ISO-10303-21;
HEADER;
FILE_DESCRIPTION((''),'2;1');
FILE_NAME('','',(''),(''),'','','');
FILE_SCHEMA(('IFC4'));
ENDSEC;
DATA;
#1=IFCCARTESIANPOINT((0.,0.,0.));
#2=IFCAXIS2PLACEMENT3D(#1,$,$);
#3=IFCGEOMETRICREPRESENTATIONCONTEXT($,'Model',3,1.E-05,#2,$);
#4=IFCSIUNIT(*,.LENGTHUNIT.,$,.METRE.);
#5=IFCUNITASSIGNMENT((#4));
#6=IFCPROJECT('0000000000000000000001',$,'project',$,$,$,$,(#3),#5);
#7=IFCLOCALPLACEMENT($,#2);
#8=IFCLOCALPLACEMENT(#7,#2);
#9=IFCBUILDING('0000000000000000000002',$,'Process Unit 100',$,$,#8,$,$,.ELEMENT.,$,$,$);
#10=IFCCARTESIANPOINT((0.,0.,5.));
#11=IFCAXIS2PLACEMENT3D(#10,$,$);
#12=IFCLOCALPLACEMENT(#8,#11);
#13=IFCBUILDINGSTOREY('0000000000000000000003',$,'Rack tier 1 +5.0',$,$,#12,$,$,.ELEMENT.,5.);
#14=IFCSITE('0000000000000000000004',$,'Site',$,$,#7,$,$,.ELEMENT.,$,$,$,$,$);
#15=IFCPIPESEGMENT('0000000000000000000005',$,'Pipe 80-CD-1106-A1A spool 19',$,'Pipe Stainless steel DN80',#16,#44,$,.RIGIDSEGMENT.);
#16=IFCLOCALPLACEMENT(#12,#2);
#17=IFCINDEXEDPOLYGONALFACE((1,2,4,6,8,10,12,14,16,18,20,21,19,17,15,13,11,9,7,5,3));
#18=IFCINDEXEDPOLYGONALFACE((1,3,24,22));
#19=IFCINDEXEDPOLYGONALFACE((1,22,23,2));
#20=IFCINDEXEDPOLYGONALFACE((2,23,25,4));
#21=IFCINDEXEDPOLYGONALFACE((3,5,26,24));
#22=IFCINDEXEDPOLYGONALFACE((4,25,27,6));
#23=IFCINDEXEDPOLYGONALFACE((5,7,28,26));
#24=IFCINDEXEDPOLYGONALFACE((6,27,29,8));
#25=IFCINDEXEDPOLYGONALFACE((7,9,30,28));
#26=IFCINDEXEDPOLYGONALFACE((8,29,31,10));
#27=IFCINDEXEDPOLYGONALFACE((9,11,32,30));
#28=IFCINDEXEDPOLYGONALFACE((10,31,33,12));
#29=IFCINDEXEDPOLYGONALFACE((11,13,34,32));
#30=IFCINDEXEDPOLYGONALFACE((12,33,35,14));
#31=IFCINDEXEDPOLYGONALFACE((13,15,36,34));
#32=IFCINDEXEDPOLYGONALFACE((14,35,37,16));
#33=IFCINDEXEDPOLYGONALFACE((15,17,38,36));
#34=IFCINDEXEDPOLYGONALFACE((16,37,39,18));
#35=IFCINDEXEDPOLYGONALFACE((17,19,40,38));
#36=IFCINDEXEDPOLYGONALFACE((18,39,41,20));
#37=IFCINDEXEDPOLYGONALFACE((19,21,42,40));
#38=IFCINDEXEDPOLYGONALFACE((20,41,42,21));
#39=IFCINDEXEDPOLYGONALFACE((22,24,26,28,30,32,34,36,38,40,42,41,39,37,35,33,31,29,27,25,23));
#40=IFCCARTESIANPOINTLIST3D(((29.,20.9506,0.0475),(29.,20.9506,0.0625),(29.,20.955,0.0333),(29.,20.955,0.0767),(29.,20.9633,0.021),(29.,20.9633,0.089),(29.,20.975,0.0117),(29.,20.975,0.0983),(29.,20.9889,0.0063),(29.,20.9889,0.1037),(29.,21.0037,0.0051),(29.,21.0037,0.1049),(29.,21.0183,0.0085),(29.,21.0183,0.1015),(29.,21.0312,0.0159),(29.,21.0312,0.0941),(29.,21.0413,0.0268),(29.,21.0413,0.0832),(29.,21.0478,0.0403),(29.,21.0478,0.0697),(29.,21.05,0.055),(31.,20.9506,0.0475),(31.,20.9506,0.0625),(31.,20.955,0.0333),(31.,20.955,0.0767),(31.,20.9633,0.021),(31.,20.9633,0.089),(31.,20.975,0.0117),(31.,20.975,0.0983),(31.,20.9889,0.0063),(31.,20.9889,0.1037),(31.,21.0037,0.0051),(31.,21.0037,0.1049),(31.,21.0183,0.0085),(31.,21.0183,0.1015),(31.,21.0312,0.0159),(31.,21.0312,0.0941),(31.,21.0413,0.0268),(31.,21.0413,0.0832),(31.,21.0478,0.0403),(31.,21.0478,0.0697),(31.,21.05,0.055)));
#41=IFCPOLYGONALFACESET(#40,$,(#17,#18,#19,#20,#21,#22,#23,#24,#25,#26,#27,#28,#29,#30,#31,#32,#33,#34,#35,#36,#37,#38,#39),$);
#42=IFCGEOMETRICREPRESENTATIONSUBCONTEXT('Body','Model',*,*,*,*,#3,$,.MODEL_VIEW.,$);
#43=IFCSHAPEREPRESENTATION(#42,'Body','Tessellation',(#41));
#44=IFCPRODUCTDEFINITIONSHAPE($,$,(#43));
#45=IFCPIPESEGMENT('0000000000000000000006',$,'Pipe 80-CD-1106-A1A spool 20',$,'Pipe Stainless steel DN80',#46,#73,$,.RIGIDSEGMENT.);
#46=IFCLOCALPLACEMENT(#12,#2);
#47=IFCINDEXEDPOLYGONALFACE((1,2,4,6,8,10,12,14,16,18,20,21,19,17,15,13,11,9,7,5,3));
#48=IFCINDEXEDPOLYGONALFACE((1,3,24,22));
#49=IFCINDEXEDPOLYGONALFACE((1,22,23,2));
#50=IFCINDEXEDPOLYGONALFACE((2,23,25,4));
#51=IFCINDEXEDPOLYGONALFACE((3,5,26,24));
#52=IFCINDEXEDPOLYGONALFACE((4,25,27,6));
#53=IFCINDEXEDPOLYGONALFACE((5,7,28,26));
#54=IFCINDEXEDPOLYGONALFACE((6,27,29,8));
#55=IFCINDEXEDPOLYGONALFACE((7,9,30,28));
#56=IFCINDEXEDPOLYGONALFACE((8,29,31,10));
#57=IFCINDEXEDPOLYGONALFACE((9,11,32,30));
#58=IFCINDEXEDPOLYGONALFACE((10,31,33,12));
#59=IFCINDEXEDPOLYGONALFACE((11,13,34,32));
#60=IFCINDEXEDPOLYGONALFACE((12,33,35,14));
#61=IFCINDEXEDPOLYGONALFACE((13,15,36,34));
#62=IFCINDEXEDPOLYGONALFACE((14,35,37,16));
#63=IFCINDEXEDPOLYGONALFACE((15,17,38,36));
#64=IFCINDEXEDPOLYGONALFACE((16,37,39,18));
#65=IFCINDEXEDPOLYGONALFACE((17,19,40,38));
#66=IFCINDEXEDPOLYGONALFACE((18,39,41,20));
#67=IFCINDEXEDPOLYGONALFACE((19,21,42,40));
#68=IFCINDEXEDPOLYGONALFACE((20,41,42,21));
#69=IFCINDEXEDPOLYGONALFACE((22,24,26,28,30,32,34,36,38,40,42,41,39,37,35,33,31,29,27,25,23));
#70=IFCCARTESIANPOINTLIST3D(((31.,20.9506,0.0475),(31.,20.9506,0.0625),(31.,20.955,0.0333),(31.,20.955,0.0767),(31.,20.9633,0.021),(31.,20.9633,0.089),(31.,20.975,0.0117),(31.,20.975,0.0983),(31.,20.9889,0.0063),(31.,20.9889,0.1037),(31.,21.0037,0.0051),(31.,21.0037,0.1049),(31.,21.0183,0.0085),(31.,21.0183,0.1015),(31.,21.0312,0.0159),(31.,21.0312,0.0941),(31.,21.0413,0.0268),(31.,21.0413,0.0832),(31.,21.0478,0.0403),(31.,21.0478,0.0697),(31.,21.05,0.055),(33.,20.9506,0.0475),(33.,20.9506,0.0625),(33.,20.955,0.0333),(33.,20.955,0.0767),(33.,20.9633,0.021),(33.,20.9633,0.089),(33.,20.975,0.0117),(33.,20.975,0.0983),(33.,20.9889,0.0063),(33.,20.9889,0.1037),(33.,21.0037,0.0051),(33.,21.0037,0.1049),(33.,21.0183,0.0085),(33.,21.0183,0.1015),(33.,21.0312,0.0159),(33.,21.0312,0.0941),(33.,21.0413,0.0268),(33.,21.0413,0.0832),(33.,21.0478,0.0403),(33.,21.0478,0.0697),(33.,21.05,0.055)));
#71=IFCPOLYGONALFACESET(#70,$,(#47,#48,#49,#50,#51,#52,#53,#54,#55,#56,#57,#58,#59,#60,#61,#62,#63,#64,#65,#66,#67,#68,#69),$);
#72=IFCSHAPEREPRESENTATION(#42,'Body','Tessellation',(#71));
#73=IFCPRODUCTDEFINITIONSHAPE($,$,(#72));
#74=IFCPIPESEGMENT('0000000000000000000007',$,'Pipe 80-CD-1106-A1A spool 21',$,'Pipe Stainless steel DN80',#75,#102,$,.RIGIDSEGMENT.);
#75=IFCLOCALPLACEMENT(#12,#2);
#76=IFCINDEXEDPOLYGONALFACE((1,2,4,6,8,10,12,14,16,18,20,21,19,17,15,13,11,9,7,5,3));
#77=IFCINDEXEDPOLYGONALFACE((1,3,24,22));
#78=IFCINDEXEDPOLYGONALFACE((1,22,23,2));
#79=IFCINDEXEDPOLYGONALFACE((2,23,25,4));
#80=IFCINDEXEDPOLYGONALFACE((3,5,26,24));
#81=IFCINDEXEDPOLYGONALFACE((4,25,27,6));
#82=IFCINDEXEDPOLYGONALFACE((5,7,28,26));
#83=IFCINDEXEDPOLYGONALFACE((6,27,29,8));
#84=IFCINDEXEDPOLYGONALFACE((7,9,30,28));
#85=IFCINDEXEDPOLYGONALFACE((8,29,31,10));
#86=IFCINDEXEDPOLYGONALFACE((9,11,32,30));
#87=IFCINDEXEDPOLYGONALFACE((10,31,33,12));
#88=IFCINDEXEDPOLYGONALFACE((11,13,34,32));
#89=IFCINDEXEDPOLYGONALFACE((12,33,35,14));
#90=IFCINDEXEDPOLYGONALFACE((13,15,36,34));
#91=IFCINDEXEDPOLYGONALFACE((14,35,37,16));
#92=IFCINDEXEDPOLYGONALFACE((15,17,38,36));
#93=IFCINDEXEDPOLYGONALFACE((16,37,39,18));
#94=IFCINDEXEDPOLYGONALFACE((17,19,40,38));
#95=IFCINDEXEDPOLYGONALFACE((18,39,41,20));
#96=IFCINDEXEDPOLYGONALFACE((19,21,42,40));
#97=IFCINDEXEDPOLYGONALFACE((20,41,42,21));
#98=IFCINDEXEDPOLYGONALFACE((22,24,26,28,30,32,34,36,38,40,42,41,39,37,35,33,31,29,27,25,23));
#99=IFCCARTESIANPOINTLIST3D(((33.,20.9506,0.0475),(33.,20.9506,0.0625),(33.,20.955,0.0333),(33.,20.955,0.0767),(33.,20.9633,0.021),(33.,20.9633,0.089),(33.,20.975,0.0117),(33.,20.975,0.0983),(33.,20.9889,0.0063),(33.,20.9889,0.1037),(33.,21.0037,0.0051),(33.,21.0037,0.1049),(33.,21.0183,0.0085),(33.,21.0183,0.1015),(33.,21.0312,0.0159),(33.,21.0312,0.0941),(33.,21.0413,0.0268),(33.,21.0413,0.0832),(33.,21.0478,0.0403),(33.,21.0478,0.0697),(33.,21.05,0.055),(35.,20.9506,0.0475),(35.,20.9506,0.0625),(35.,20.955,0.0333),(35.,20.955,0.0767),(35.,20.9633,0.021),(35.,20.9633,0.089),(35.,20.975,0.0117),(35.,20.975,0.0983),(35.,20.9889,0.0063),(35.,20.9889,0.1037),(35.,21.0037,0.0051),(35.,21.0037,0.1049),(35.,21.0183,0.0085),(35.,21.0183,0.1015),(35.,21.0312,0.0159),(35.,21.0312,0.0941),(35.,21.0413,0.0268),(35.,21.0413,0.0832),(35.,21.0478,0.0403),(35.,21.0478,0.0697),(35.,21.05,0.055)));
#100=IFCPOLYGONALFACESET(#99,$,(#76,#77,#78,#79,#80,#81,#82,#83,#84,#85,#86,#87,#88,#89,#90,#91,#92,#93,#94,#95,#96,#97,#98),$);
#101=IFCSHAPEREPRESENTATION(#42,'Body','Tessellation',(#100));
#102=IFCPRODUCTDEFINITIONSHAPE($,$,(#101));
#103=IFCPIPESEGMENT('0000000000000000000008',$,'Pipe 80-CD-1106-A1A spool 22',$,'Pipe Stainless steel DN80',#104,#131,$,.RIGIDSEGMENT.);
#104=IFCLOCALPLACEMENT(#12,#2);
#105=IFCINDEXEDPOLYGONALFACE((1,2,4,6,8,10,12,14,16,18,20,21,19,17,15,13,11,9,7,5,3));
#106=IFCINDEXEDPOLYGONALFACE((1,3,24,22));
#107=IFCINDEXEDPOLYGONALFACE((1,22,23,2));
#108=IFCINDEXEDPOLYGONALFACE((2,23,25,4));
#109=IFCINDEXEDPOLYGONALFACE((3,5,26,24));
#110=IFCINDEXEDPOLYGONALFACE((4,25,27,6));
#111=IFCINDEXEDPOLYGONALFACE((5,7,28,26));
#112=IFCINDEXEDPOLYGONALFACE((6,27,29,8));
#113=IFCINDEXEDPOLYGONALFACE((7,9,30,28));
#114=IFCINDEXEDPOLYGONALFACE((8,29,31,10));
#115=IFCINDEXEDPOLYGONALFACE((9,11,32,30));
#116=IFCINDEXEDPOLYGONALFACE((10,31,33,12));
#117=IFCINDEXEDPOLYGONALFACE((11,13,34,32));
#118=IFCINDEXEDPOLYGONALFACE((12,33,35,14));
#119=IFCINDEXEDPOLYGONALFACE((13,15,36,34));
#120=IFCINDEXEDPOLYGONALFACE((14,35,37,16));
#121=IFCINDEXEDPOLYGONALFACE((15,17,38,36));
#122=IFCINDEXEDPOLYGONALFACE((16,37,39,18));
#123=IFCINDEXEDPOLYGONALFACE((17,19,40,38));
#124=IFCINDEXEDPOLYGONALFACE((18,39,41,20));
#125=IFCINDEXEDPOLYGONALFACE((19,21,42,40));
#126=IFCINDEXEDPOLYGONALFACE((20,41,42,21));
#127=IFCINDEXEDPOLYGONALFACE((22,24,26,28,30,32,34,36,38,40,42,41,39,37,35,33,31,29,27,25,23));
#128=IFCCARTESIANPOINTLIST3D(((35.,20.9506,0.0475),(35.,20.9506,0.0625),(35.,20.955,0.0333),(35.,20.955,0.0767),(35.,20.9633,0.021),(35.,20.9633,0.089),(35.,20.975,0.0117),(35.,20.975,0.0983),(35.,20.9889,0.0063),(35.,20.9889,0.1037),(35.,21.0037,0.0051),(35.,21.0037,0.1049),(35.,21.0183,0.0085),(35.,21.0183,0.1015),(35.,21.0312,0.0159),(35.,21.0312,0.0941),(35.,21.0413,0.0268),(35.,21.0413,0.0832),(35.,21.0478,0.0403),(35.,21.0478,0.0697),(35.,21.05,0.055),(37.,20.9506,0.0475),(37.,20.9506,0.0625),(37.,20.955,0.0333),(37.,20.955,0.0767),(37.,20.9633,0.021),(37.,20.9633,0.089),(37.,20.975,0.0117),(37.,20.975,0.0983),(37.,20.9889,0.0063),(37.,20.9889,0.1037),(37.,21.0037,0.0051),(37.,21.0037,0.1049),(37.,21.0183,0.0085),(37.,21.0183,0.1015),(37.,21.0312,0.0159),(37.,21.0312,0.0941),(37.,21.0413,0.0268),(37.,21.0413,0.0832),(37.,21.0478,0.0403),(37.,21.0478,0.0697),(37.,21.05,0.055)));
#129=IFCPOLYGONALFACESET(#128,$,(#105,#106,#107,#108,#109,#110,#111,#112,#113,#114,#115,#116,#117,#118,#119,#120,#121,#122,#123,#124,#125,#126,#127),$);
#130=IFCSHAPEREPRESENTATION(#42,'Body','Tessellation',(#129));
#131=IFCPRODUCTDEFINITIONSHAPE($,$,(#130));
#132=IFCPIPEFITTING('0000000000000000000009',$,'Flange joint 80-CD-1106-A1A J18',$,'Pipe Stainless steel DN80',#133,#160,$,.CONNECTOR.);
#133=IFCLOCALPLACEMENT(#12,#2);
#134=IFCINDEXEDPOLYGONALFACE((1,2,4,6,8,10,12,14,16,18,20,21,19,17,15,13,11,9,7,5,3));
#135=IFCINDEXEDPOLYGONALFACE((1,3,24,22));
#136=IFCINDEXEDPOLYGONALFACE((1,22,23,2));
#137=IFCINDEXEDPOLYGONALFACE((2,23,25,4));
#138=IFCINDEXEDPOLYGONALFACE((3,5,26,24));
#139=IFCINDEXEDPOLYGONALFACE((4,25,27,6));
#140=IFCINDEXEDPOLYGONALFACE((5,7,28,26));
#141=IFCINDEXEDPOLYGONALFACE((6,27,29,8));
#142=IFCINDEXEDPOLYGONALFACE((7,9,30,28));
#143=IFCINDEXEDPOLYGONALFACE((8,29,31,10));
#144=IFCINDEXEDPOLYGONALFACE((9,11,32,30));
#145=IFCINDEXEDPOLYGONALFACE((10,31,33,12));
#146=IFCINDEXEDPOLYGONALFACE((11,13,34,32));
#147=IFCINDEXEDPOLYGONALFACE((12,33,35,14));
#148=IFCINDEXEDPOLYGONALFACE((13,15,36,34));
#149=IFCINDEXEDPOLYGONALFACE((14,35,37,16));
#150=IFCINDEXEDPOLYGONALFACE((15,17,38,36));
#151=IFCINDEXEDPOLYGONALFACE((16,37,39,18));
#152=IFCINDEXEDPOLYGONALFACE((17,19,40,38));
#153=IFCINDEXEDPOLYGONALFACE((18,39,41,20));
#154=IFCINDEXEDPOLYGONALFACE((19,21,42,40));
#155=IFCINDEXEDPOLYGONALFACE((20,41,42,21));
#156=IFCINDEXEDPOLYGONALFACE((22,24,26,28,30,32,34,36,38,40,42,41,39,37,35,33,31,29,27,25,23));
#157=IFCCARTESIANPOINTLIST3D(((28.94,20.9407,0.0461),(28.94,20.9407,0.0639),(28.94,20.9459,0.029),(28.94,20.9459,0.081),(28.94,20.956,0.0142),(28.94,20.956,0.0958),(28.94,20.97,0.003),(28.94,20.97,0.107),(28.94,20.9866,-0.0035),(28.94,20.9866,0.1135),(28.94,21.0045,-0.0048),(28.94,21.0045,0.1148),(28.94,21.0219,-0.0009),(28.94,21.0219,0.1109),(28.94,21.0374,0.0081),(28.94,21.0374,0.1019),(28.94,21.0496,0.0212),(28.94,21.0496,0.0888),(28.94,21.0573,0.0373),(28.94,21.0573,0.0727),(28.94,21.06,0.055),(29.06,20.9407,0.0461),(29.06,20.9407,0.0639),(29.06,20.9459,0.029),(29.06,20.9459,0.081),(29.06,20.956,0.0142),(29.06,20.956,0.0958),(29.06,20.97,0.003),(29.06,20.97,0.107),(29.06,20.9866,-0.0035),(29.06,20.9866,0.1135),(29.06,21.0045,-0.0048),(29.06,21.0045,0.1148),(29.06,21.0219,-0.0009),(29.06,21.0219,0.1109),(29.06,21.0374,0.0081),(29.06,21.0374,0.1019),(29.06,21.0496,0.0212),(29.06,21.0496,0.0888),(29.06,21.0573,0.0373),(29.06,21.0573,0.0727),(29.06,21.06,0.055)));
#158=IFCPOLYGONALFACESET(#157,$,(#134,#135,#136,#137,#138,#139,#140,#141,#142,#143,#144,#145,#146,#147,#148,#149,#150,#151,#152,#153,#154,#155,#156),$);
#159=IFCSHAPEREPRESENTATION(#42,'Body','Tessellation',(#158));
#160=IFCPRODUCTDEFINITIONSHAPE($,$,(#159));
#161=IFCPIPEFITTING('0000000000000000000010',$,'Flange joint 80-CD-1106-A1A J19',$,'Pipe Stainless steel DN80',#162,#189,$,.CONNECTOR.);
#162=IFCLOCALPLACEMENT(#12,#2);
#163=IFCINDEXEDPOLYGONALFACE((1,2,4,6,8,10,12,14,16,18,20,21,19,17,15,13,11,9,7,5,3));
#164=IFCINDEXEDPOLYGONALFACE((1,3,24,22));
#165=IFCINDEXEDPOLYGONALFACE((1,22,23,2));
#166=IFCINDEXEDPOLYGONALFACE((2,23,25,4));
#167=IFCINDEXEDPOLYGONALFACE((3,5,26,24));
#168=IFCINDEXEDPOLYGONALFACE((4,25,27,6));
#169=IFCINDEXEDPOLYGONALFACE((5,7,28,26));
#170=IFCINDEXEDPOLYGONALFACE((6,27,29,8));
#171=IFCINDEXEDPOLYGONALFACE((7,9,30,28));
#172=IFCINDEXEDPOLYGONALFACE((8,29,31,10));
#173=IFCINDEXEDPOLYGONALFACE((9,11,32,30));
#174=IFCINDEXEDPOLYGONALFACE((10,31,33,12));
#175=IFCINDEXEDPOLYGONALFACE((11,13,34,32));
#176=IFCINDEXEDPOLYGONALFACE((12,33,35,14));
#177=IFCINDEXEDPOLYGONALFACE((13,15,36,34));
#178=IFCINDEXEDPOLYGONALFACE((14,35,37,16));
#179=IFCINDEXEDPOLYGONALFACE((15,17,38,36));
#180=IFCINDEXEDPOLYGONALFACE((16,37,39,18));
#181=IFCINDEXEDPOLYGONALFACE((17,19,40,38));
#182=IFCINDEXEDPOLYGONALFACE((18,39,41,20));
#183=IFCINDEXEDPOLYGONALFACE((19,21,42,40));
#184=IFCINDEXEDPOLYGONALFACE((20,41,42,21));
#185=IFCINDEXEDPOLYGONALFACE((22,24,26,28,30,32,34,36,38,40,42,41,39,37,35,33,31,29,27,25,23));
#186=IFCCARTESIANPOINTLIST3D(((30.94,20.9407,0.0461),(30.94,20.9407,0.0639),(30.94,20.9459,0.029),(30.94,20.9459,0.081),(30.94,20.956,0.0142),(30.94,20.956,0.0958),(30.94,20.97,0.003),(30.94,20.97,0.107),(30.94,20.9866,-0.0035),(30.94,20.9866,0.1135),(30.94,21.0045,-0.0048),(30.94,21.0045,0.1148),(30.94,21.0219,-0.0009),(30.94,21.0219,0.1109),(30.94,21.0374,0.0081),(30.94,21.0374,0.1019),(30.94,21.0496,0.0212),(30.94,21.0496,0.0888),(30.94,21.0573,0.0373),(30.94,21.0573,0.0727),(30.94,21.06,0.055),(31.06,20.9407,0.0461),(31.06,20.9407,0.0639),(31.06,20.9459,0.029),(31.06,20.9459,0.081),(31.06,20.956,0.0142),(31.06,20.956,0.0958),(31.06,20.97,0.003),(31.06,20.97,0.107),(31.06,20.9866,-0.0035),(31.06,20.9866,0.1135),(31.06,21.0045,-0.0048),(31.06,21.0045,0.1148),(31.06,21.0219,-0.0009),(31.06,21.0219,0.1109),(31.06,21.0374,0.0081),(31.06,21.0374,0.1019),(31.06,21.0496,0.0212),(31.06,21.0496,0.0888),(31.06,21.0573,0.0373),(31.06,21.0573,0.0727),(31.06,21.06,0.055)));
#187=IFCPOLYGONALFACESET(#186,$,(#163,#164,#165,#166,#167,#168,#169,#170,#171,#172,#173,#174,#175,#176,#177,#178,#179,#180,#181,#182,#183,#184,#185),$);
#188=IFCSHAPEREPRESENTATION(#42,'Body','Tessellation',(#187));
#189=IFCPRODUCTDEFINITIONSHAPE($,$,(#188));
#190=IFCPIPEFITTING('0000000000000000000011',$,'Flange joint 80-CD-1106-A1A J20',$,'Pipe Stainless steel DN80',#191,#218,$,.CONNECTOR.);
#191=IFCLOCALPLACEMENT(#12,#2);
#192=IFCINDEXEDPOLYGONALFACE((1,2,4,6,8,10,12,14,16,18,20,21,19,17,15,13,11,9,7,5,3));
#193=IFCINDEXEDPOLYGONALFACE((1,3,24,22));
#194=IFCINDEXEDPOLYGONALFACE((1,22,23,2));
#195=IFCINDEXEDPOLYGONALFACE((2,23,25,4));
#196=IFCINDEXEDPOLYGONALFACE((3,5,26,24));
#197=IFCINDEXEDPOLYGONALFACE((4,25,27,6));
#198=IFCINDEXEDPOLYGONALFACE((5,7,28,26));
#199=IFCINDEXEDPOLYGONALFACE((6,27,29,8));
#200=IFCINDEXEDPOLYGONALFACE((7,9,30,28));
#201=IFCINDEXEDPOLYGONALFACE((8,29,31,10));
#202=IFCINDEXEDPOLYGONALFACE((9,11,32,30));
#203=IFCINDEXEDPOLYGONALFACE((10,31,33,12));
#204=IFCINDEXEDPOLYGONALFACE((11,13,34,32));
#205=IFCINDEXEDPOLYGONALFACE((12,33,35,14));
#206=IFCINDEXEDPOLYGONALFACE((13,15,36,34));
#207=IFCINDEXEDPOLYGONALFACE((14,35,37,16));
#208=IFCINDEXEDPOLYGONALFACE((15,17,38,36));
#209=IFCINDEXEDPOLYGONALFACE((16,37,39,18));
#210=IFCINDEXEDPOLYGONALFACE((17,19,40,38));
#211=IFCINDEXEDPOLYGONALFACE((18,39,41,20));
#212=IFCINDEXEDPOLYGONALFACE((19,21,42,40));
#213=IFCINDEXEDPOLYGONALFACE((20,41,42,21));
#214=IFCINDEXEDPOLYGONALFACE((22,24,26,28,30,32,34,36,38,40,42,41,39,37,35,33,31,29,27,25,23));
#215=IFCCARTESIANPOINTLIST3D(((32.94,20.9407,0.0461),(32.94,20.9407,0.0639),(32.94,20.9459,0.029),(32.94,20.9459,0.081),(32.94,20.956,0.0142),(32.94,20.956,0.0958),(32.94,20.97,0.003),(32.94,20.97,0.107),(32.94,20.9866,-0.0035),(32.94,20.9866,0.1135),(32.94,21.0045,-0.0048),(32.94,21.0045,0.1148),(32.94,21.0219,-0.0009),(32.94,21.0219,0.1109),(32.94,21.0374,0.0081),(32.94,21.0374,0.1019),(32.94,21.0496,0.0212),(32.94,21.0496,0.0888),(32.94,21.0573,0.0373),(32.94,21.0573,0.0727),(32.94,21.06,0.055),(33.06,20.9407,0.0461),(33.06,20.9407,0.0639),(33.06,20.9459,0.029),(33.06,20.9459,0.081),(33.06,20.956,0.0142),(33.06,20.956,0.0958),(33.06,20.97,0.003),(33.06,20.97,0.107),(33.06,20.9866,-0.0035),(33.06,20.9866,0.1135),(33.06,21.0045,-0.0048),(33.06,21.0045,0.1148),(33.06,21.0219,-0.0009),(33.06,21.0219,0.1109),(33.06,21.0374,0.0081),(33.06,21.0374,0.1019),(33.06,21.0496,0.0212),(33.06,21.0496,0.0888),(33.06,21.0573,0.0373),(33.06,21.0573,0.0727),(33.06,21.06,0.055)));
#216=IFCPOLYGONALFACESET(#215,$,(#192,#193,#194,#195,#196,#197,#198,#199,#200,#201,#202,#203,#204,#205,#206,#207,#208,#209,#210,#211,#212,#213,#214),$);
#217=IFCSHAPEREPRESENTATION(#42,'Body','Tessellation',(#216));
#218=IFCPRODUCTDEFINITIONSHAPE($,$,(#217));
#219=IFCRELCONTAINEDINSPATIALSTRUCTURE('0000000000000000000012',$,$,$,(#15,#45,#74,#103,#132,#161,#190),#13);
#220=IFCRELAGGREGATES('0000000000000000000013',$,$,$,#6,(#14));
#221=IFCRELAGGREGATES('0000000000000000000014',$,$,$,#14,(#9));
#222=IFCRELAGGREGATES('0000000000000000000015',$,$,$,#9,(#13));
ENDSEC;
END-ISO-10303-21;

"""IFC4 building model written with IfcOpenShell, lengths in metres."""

from ifc_helpers import new_model, si_unit, frame, origin, place, context, subcontext, project, spatial, circle, extrude, element, save


model = new_model("IFC4")

# Units and contexts
model_context = context("Model", 3, precision=1e-05, world=origin())
body_context = subcontext(model_context, "Body", "Model", "MODEL_VIEW")
ifc_project = project(units=[si_unit("LENGTHUNIT", "METRE")], contexts=[model_context])

# Site, building, storey
site_placement = place(None, origin())
site = spatial("IfcSite", under=ifc_project, at=site_placement, Name="Site", CompositionType="ELEMENT")
building_placement = place(site_placement, origin())
building = spatial("IfcBuilding", under=site, at=building_placement, Name="Process Unit 100", CompositionType="ELEMENT")
storey_placement = place(building_placement, frame((0.0, 0.0, 5.0)))
storey = spatial("IfcBuildingStorey", under=building, at=storey_placement, Name="Rack tier 1 +5.0", CompositionType="ELEMENT", Elevation=5.0)

# Pipe segments
for number, where, z_axis, x_axis, name in (
    (1, (29.0, 21.0, 0.055), (1.0, 0.0, 0.0), (0.0, 1.0, 0.0), "Pipe 80-CD-1106-A1A spool 19"),
    (2, (31.0, 21.0, 0.055), (1.0, 0.0, 0.0), (0.0, 1.0, 0.0), "Pipe 80-CD-1106-A1A spool 20"),
    (3, (33.0, 21.0, 0.055), (1.0, 0.0, 0.0), (0.0, 1.0, 0.0), "Pipe 80-CD-1106-A1A spool 21"),
    (4, (35.0, 21.0, 0.055), (1.0, 0.0, 0.0), (0.0, 1.0, 0.0), "Pipe 80-CD-1106-A1A spool 22"),
):
    element("IfcPipeSegment", number, at=place(storey_placement, frame(where, z_axis=z_axis, x_axis=x_axis)), inside=storey, Name=name, ObjectType="Pipe Stainless steel DN80", PredefinedType="RIGIDSEGMENT", context=body_context, shape_type="SweptSolid", body=[
        extrude(circle(Radius=0.05), origin(), (0.0, 0.0, 1.0), 2.0),
    ])

# Pipe fittings
for number, where, z_axis, x_axis, name in (
    (5, (28.94, 21.0, 0.055), (1.0, 0.0, 0.0), (0.0, 1.0, 0.0), "Flange joint 80-CD-1106-A1A J18"),
    (6, (30.94, 21.0, 0.055), (1.0, 0.0, 0.0), (0.0, 1.0, 0.0), "Flange joint 80-CD-1106-A1A J19"),
    (7, (32.94, 21.0, 0.055), (1.0, 0.0, 0.0), (0.0, 1.0, 0.0), "Flange joint 80-CD-1106-A1A J20"),
):
    element("IfcPipeFitting", number, at=place(storey_placement, frame(where, z_axis=z_axis, x_axis=x_axis)), inside=storey, Name=name, ObjectType="Pipe Stainless steel DN80", PredefinedType="CONNECTOR", context=body_context, shape_type="SweptSolid", body=[
        extrude(circle(Radius=0.06), origin(), (0.0, 0.0, 1.0), 0.12),
    ])

save(model, "model.ifc")
